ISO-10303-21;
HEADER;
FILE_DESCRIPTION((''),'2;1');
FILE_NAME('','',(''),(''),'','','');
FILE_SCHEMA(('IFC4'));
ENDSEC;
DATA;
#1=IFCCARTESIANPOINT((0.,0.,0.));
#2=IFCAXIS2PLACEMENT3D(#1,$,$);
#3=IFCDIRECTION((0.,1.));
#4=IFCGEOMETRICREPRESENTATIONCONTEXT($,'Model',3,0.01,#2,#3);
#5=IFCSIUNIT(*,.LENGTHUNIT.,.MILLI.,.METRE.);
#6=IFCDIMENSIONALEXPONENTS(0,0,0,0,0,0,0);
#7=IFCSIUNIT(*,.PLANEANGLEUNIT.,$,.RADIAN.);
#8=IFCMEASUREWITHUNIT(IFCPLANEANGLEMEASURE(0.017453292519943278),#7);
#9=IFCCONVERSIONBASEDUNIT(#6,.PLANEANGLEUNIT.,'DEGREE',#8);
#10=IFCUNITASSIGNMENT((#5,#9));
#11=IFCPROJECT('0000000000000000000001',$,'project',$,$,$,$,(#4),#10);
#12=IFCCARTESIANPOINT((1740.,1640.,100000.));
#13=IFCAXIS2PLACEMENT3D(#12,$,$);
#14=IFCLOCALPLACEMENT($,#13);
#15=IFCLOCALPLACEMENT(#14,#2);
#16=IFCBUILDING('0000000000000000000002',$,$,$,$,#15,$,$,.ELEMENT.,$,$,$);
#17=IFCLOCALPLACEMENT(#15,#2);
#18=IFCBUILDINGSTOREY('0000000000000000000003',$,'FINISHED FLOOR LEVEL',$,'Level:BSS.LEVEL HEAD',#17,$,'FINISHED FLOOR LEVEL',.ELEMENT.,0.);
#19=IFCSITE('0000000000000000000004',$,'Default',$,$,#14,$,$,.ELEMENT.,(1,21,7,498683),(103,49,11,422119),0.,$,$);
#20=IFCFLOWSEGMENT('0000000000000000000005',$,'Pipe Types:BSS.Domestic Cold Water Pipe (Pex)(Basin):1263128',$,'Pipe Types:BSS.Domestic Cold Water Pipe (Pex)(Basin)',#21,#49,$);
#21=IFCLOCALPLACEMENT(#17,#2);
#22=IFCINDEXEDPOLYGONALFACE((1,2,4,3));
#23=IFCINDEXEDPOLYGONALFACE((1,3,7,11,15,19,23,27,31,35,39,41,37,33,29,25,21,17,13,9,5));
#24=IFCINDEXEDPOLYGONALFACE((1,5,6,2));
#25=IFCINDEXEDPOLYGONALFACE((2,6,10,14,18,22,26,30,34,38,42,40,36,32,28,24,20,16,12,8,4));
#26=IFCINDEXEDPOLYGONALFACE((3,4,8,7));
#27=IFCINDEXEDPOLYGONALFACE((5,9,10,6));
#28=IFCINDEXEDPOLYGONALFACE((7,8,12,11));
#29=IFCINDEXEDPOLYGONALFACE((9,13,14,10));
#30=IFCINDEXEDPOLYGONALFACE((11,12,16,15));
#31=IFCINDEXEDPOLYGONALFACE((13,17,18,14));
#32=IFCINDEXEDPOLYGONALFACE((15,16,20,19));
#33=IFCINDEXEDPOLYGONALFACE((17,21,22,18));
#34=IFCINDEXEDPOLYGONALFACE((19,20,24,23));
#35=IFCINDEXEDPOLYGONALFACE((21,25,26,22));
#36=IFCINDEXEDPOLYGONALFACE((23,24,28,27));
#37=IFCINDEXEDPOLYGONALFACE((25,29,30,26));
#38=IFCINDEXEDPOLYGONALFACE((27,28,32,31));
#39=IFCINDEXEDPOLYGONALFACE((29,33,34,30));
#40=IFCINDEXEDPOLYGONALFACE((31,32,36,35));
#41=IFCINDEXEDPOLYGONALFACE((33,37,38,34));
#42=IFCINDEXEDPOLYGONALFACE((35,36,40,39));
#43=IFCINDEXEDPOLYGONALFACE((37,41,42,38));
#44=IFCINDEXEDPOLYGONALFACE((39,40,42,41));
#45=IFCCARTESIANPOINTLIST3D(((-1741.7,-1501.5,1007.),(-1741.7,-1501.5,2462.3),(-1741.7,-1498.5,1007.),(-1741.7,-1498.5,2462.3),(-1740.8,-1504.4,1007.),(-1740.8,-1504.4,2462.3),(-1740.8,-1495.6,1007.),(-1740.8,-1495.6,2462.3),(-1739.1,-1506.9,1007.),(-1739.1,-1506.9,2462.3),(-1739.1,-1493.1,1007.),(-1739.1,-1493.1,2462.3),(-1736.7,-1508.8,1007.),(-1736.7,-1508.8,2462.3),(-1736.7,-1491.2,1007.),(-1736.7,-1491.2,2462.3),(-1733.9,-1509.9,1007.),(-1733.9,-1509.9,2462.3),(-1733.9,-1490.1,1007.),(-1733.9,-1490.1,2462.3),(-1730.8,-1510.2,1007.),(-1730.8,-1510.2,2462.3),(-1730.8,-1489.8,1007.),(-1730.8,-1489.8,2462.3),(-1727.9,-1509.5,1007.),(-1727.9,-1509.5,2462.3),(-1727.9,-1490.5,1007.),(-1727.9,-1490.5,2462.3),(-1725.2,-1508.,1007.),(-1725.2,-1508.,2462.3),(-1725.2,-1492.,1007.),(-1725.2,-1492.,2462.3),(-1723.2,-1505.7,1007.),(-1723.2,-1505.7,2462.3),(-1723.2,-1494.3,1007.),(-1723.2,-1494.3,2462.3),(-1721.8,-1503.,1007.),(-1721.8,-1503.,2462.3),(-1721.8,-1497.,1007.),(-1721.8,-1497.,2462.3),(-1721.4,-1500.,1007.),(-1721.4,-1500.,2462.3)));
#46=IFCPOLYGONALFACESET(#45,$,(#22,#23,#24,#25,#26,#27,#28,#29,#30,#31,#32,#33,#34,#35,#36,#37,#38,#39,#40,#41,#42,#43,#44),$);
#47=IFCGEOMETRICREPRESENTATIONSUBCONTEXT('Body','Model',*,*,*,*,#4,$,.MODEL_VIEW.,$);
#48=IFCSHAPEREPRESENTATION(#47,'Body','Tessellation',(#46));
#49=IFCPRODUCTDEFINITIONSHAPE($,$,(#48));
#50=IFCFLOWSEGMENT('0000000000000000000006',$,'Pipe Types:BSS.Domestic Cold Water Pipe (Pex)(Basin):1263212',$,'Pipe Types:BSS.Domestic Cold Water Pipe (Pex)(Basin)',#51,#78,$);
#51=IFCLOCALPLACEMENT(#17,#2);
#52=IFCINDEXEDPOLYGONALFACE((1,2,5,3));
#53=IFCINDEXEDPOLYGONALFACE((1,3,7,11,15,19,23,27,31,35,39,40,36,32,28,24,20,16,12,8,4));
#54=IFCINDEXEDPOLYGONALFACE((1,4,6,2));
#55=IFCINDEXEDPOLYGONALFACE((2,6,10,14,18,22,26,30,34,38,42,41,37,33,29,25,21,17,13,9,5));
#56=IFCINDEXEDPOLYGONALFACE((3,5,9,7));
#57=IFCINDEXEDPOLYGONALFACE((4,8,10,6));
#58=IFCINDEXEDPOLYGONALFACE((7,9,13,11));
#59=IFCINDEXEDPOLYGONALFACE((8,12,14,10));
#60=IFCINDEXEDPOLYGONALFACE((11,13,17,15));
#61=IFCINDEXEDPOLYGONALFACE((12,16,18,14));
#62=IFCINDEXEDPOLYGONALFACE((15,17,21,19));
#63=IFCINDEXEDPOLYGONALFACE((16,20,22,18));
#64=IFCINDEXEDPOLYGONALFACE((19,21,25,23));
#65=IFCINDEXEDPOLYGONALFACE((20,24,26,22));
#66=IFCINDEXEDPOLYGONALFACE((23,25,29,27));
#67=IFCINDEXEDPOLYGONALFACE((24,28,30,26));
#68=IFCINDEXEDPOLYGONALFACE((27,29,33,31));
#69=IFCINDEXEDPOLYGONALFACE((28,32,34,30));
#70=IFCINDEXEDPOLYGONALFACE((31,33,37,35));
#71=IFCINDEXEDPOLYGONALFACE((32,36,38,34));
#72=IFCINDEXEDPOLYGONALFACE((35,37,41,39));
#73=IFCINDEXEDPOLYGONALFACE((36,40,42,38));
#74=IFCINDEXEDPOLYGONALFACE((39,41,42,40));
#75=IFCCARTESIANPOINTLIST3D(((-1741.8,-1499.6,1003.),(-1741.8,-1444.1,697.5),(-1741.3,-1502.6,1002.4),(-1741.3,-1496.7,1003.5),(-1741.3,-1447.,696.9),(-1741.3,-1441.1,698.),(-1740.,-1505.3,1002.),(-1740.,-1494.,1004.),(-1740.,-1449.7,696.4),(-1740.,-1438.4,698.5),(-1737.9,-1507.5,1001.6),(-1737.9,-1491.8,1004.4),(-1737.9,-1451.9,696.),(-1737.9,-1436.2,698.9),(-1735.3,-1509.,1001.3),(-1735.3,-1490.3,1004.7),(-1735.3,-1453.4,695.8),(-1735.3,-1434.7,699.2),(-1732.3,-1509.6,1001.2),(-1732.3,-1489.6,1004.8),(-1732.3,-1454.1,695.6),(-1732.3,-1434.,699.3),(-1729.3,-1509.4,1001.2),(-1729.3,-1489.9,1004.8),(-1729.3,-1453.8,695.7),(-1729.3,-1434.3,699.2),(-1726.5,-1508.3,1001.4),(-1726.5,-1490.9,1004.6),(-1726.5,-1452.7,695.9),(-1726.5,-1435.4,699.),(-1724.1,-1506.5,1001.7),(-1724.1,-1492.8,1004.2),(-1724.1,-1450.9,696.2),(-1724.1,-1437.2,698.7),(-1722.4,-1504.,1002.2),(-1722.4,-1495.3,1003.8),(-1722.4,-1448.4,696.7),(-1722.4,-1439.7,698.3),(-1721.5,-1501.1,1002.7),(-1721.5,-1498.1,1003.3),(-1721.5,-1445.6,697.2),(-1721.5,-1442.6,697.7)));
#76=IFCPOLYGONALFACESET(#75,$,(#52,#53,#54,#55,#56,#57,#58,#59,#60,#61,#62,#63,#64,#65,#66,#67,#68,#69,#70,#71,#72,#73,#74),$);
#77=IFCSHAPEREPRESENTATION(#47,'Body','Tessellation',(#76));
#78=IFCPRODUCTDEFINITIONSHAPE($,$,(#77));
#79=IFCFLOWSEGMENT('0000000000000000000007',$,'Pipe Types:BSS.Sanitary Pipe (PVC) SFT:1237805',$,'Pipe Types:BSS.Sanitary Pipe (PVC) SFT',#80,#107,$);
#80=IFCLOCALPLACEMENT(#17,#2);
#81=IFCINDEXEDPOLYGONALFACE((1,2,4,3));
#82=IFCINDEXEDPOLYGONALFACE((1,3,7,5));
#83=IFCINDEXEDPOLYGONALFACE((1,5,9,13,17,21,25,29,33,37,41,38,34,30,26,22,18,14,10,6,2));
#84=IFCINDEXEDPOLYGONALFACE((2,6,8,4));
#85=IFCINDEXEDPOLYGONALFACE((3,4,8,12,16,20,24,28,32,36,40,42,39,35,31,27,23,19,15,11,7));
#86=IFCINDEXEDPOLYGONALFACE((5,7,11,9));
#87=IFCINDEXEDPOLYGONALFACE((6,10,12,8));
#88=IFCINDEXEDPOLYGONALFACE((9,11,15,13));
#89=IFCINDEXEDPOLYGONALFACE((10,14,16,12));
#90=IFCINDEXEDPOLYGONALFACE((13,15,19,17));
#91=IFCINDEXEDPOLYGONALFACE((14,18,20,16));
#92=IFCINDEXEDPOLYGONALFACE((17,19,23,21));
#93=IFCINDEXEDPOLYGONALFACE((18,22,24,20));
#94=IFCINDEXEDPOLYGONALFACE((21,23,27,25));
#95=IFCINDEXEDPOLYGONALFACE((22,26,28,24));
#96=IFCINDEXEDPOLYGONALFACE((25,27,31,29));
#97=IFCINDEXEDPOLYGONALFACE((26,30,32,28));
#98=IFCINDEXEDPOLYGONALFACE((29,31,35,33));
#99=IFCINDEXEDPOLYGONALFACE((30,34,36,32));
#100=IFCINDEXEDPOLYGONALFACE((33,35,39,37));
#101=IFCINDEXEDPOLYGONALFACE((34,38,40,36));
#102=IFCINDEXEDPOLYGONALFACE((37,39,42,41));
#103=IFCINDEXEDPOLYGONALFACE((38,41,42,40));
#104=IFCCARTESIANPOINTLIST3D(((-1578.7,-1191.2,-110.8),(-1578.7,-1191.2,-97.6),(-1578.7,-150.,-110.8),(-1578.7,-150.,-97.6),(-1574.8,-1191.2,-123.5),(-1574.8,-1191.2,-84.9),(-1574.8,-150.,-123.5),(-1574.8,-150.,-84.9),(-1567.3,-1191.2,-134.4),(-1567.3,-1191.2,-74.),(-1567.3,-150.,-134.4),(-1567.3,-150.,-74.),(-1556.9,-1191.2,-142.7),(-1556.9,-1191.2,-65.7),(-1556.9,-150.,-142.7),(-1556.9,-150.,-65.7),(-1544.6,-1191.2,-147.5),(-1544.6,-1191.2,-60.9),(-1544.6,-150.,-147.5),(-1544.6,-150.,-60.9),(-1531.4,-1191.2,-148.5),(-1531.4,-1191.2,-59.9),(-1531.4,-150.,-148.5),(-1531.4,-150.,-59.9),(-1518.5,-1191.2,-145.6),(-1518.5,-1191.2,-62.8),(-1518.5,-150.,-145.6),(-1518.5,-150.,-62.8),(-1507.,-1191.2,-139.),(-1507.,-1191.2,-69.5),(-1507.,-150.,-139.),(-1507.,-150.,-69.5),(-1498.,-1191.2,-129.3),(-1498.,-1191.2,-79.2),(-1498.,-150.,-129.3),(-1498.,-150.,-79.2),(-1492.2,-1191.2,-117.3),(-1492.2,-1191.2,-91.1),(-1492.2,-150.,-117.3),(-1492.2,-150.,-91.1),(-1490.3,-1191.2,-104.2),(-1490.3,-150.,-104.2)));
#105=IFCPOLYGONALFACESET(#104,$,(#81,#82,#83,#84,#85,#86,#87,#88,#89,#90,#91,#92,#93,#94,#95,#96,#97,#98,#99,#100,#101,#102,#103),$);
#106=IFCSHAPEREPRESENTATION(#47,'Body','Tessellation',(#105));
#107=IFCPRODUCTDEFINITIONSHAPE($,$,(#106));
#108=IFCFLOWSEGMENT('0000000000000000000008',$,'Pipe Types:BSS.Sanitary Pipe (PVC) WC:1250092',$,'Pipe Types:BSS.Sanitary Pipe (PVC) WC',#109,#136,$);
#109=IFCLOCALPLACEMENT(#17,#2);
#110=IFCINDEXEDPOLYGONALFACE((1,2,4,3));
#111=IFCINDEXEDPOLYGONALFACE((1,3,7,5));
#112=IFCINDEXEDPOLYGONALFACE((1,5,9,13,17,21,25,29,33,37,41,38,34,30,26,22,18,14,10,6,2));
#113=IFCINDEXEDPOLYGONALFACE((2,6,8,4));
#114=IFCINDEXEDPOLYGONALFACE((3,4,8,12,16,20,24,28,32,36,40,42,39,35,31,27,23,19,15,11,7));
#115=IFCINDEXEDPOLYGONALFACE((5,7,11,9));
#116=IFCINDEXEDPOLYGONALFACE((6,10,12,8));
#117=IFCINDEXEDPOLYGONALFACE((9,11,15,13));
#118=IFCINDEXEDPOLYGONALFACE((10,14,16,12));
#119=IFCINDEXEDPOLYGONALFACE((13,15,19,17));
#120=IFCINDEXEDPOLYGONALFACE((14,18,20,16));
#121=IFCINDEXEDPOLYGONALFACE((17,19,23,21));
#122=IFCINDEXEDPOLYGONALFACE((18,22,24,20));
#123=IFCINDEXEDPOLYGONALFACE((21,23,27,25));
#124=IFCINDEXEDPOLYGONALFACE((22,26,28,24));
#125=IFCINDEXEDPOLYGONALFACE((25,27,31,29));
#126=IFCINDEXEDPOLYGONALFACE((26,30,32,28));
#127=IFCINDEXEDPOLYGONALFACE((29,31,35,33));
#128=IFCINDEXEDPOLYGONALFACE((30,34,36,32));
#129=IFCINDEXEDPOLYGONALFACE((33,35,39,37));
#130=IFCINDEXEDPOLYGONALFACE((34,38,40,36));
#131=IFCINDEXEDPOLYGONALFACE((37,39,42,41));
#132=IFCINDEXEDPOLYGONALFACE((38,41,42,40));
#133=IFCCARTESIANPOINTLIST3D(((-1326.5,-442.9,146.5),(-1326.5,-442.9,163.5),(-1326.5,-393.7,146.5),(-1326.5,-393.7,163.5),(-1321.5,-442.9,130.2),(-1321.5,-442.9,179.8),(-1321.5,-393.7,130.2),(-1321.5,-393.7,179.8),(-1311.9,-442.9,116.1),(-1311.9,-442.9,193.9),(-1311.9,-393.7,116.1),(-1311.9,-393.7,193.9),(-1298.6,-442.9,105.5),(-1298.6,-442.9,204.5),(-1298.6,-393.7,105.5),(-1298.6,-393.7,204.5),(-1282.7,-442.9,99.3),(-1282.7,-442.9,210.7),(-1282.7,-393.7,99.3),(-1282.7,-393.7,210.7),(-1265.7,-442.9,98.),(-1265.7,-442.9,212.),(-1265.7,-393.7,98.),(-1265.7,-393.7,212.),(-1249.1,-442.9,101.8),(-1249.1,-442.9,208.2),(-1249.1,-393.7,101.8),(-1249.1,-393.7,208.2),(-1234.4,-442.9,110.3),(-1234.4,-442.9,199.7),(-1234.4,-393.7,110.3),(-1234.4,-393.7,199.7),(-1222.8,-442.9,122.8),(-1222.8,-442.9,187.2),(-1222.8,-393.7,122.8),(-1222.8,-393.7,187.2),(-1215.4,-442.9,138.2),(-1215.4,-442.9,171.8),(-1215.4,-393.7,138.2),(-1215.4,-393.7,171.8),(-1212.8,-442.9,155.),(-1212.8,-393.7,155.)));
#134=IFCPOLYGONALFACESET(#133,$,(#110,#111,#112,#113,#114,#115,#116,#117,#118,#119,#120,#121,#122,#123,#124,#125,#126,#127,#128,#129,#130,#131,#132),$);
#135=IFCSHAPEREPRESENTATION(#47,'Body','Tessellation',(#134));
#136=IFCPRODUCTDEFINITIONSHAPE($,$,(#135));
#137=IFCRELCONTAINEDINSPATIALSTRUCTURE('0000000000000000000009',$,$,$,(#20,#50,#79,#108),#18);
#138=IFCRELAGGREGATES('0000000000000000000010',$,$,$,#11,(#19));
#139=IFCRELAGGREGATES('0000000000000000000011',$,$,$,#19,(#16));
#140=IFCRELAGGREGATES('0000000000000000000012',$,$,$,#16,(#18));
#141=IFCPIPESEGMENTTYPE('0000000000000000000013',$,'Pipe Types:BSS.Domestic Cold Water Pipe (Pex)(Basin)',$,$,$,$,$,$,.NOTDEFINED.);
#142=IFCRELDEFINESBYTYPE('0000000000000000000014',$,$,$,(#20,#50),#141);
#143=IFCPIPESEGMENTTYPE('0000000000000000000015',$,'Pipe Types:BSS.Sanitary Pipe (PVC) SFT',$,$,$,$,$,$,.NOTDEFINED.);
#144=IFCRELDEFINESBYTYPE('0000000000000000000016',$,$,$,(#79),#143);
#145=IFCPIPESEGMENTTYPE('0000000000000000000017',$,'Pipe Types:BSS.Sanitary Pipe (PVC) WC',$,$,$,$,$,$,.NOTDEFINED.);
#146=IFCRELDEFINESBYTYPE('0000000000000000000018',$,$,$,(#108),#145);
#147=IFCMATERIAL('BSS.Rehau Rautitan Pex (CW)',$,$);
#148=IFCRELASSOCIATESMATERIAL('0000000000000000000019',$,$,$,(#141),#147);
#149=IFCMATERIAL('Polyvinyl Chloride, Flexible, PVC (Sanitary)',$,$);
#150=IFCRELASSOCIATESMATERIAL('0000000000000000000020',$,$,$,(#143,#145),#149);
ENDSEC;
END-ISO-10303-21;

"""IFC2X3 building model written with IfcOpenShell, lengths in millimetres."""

from ifc_helpers import new_model, entity, si_unit, converted_unit, direction, frame, frame_2d, origin, origin_2d_with_axis, place, context, subcontext, project, spatial, circle, extrude, material, type_object, element, save


model = new_model("IFC2X3")

# Units and contexts
model_context = context("Model", 3, precision=0.01, world=origin(), true_north=direction((0.0, 1.0)))
body_context = subcontext(model_context, "Body", "Model", "MODEL_VIEW")
ifc_project = project(units=[si_unit("LENGTHUNIT", "METRE", prefix="MILLI"), converted_unit("PLANEANGLEUNIT", "DEGREE", entity("IfcPlaneAngleMeasure", 0.017453292519943278), si_unit("PLANEANGLEUNIT", "RADIAN"), dimensions=[0, 0, 0, 0, 0, 0, 0])], contexts=[model_context])

# Site, building, storey
site_placement = place(None, frame((1740.0, 1640.0, 100000.0)))
site = spatial("IfcSite", under=ifc_project, at=site_placement, Name="Default", CompositionType="ELEMENT", RefLatitude=(1, 21, 7, 498683), RefLongitude=(103, 49, 11, 422119), RefElevation=0.0)
building_placement = place(site_placement, origin())
building = spatial("IfcBuilding", under=site, at=building_placement, CompositionType="ELEMENT")
storey_placement = place(building_placement, origin())
storey = spatial("IfcBuildingStorey", under=building, at=storey_placement, Name="FINISHED FLOOR LEVEL", ObjectType="Level:BSS.LEVEL HEAD", LongName="FINISHED FLOOR LEVEL", CompositionType="ELEMENT", Elevation=0.0)

# Flow segments
ifc_material_1 = material(Name="BSS.Rehau Rautitan Pex (CW)")
pipe_segment_type_1 = type_object("IfcPipeSegmentType", Name="Pipe Types:BSS.Domestic Cold Water Pipe (Pex)(Basin)", PredefinedType="NOTDEFINED", material=ifc_material_1)
flow_segment_1_placement = place(storey_placement, origin())
element("IfcFlowSegment", 1, at=flow_segment_1_placement, inside=storey, type_object=pipe_segment_type_1, Name="Pipe Types:BSS.Domestic Cold Water Pipe (Pex)(Basin):1263128", ObjectType="Pipe Types:BSS.Domestic Cold Water Pipe (Pex)(Basin)", context=body_context, shape_type="SweptSolid", body=[
    extrude(circle(Radius=10.2, at=origin_2d_with_axis()), frame((-1731.6, -1500.0, 1007.0)), (0.0, 0.0, 1.0), 1455.3),
])
flow_segment_2_placement = place(storey_placement, origin())
element("IfcFlowSegment", 2, at=flow_segment_2_placement, inside=storey, type_object=pipe_segment_type_1, Name="Pipe Types:BSS.Domestic Cold Water Pipe (Pex)(Basin):1263212", ObjectType="Pipe Types:BSS.Domestic Cold Water Pipe (Pex)(Basin)", context=body_context, shape_type="SweptSolid", body=[
    extrude(circle(Radius=10.2, at=origin_2d_with_axis()), frame((-1731.6, -1499.6, 1003.0), z_axis=(0.0, 0.178966, -0.983855), x_axis=(-1.0, 0.0, 0.0)), (0.0, 0.0, 1.0), 310.5),
])
ifc_material_2 = material(Name="Polyvinyl Chloride, Flexible, PVC (Sanitary)")
pipe_segment_type_2 = type_object("IfcPipeSegmentType", Name="Pipe Types:BSS.Sanitary Pipe (PVC) SFT", PredefinedType="NOTDEFINED", material=ifc_material_2)
flow_segment_3_placement = place(storey_placement, origin())
element("IfcFlowSegment", 3, at=flow_segment_3_placement, inside=storey, type_object=pipe_segment_type_2, Name="Pipe Types:BSS.Sanitary Pipe (PVC) SFT:1237805", ObjectType="Pipe Types:BSS.Sanitary Pipe (PVC) SFT", context=body_context, shape_type="SweptSolid", body=[
    extrude(circle(Radius=44.5, at=frame_2d((0.0, 0.0), x_axis=(1.0, 0.0))), frame((-1534.7, -1191.2, -104.2), z_axis=(0.0, 1.0, 0.0), x_axis=(1.0, 0.0, 0.0)), (0.0, 0.0, 1.0), 1041.2),
])
pipe_segment_type_3 = type_object("IfcPipeSegmentType", Name="Pipe Types:BSS.Sanitary Pipe (PVC) WC", PredefinedType="NOTDEFINED", material=ifc_material_2)
flow_segment_4_placement = place(storey_placement, origin())
element("IfcFlowSegment", 4, at=flow_segment_4_placement, inside=storey, type_object=pipe_segment_type_3, Name="Pipe Types:BSS.Sanitary Pipe (PVC) WC:1250092", ObjectType="Pipe Types:BSS.Sanitary Pipe (PVC) WC", context=body_context, shape_type="SweptSolid", body=[
    extrude(circle(Radius=57.2, at=frame_2d((0.0, 0.0), x_axis=(1.0, 0.0))), frame((-1270.0, -442.9, 155.0), z_axis=(0.0, 1.0, 0.0), x_axis=(1.0, 0.0, 0.0)), (0.0, 0.0, 1.0), 49.2),
])

save(model, "model.ifc")
